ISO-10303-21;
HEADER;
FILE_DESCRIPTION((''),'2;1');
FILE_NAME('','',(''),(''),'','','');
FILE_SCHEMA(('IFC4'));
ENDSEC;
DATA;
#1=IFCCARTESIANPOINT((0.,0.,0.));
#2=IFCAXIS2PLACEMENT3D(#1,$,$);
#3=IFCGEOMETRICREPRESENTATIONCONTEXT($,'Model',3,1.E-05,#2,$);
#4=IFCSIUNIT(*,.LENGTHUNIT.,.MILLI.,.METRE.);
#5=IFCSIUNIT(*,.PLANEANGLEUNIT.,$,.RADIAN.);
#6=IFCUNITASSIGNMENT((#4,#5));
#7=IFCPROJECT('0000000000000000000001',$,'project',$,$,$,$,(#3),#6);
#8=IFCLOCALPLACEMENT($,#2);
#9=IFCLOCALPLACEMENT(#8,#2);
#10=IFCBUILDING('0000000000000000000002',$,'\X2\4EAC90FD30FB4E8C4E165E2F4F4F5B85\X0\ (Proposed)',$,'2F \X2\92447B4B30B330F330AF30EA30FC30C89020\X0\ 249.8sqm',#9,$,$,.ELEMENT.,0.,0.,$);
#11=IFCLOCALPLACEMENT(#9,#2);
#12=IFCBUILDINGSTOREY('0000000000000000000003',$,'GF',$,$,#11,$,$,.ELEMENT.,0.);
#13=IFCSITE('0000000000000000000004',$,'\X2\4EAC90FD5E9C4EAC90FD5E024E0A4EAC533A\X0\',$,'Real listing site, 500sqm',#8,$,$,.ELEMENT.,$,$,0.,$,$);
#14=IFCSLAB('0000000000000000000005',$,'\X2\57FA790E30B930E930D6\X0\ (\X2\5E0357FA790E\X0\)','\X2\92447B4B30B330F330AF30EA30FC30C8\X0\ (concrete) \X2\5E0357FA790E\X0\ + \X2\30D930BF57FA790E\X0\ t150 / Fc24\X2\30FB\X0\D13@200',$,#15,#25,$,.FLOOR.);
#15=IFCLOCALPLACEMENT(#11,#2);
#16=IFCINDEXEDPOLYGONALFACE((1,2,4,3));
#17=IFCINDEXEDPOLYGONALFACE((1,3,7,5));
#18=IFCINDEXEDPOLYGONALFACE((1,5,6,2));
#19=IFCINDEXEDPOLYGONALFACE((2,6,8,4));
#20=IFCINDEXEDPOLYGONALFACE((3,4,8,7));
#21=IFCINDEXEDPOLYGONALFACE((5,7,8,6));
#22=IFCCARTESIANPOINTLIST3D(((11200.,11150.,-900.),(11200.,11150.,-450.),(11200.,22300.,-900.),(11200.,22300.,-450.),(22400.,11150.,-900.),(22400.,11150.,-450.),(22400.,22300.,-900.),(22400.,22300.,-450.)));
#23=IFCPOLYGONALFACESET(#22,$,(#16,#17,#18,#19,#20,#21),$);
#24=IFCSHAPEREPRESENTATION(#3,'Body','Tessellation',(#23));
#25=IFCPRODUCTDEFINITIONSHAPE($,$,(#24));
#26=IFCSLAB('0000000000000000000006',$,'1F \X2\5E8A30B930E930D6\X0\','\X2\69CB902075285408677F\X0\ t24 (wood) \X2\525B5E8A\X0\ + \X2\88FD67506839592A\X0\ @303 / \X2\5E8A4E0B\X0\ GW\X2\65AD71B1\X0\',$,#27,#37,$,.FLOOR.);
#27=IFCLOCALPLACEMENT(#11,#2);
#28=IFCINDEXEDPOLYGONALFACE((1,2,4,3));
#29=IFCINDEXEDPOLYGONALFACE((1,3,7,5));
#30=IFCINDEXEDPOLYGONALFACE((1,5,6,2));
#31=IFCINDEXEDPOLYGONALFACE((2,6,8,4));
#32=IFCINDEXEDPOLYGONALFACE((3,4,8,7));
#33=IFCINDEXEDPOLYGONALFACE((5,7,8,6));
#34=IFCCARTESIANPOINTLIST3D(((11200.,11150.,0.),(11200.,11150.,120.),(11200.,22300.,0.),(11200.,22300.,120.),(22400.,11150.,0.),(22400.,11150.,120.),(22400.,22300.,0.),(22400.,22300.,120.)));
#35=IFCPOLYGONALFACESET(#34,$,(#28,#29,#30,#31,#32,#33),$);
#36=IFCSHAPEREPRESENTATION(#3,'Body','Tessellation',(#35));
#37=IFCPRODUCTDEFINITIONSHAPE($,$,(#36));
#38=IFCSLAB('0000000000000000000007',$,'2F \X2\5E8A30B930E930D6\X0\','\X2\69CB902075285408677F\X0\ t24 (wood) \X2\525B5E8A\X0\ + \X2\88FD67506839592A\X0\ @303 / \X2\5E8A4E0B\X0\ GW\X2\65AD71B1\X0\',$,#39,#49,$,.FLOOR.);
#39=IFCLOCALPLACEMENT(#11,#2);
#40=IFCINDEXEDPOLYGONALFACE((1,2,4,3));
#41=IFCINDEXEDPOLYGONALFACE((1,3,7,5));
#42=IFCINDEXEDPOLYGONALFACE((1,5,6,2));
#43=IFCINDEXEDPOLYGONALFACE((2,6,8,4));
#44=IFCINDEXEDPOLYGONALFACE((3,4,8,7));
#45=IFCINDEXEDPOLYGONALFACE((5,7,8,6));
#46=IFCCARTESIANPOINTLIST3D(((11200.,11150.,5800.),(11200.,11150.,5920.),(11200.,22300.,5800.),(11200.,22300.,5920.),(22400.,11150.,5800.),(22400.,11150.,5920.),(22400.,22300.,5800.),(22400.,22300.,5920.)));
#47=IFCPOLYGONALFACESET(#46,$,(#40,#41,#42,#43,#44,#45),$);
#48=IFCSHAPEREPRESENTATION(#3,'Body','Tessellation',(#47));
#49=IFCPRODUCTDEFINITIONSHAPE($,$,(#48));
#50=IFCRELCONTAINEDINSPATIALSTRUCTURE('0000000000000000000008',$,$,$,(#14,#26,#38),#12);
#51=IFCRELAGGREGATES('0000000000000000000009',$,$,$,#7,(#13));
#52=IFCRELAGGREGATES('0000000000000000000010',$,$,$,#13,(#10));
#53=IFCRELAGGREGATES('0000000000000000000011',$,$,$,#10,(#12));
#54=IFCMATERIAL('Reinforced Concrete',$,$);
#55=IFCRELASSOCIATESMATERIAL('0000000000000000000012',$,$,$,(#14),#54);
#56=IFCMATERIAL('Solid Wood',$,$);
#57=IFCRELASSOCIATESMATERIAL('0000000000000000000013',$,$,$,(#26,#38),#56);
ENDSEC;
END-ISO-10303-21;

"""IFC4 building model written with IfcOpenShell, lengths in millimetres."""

from ifc_helpers import new_model, si_unit, frame, frame_2d, origin, place, context, project, spatial, rectangle, extrude, material, element, save


model = new_model("IFC4")

# Units and contexts
model_context = context("Model", 3, precision=1e-05, world=origin())
ifc_project = project(units=[si_unit("LENGTHUNIT", "METRE", prefix="MILLI"), si_unit("PLANEANGLEUNIT", "RADIAN")], contexts=[model_context])

# Site, building, storey
site_placement = place(None, origin())
site = spatial("IfcSite", under=ifc_project, at=site_placement, Name="京都府京都市上京区", ObjectType="Real listing site, 500sqm", CompositionType="ELEMENT", RefElevation=0.0)
building_placement = place(site_placement, origin())
building = spatial("IfcBuilding", under=site, at=building_placement, Name="京都・二世帯住宅 (Proposed)", ObjectType="2F 鉄筋コンクリート造 249.8sqm", CompositionType="ELEMENT", ElevationOfRefHeight=0.0, ElevationOfTerrain=0.0)
storey_placement = place(building_placement, origin())
storey = spatial("IfcBuildingStorey", under=building, at=storey_placement, Name="GF", CompositionType="ELEMENT", Elevation=0.0)

# Shared definitions
ifc_material_1 = material(Name="Solid Wood")

# Slabs
ifc_material_2 = material(Name="Reinforced Concrete")
slab_1_placement = place(storey_placement, frame((5600.0, 5575.0, -450.0)))
element("IfcSlab", 1, at=slab_1_placement, inside=storey, material=ifc_material_2, Name="基礎スラブ (布基礎)", Description="鉄筋コンクリート (concrete) 布基礎 + ベタ基礎 t150 / Fc24・D13@200", PredefinedType="FLOOR", context=model_context, shape_type="SweptSolid", body=[
    extrude(rectangle(XDim=11200.0, YDim=11150.0, at=frame_2d((5600.0, 5575.0))), frame((5600.0, 5575.0, -450.0)), (0.0, 0.0, 1.0), 450.0),
])
slab_2_placement = place(storey_placement, frame((5600.0, 5575.0, 0.0)))
element("IfcSlab", 2, at=slab_2_placement, inside=storey, material=ifc_material_1, Name="1F 床スラブ", Description="構造用合板 t24 (wood) 剛床 + 製材根太 @303 / 床下 GW断熱", PredefinedType="FLOOR", context=model_context, shape_type="SweptSolid", body=[
    extrude(rectangle(XDim=11200.0, YDim=11150.0, at=frame_2d((5600.0, 5575.0))), frame((5600.0, 5575.0, 0.0)), (0.0, 0.0, 1.0), 120.0),
])
slab_3_placement = place(storey_placement, frame((5600.0, 5575.0, 2900.0)))
element("IfcSlab", 3, at=slab_3_placement, inside=storey, material=ifc_material_1, Name="2F 床スラブ", Description="構造用合板 t24 (wood) 剛床 + 製材根太 @303 / 床下 GW断熱", PredefinedType="FLOOR", context=model_context, shape_type="SweptSolid", body=[
    extrude(rectangle(XDim=11200.0, YDim=11150.0, at=frame_2d((5600.0, 5575.0))), frame((5600.0, 5575.0, 2900.0)), (0.0, 0.0, 1.0), 120.0),
])

save(model, "model.ifc")
